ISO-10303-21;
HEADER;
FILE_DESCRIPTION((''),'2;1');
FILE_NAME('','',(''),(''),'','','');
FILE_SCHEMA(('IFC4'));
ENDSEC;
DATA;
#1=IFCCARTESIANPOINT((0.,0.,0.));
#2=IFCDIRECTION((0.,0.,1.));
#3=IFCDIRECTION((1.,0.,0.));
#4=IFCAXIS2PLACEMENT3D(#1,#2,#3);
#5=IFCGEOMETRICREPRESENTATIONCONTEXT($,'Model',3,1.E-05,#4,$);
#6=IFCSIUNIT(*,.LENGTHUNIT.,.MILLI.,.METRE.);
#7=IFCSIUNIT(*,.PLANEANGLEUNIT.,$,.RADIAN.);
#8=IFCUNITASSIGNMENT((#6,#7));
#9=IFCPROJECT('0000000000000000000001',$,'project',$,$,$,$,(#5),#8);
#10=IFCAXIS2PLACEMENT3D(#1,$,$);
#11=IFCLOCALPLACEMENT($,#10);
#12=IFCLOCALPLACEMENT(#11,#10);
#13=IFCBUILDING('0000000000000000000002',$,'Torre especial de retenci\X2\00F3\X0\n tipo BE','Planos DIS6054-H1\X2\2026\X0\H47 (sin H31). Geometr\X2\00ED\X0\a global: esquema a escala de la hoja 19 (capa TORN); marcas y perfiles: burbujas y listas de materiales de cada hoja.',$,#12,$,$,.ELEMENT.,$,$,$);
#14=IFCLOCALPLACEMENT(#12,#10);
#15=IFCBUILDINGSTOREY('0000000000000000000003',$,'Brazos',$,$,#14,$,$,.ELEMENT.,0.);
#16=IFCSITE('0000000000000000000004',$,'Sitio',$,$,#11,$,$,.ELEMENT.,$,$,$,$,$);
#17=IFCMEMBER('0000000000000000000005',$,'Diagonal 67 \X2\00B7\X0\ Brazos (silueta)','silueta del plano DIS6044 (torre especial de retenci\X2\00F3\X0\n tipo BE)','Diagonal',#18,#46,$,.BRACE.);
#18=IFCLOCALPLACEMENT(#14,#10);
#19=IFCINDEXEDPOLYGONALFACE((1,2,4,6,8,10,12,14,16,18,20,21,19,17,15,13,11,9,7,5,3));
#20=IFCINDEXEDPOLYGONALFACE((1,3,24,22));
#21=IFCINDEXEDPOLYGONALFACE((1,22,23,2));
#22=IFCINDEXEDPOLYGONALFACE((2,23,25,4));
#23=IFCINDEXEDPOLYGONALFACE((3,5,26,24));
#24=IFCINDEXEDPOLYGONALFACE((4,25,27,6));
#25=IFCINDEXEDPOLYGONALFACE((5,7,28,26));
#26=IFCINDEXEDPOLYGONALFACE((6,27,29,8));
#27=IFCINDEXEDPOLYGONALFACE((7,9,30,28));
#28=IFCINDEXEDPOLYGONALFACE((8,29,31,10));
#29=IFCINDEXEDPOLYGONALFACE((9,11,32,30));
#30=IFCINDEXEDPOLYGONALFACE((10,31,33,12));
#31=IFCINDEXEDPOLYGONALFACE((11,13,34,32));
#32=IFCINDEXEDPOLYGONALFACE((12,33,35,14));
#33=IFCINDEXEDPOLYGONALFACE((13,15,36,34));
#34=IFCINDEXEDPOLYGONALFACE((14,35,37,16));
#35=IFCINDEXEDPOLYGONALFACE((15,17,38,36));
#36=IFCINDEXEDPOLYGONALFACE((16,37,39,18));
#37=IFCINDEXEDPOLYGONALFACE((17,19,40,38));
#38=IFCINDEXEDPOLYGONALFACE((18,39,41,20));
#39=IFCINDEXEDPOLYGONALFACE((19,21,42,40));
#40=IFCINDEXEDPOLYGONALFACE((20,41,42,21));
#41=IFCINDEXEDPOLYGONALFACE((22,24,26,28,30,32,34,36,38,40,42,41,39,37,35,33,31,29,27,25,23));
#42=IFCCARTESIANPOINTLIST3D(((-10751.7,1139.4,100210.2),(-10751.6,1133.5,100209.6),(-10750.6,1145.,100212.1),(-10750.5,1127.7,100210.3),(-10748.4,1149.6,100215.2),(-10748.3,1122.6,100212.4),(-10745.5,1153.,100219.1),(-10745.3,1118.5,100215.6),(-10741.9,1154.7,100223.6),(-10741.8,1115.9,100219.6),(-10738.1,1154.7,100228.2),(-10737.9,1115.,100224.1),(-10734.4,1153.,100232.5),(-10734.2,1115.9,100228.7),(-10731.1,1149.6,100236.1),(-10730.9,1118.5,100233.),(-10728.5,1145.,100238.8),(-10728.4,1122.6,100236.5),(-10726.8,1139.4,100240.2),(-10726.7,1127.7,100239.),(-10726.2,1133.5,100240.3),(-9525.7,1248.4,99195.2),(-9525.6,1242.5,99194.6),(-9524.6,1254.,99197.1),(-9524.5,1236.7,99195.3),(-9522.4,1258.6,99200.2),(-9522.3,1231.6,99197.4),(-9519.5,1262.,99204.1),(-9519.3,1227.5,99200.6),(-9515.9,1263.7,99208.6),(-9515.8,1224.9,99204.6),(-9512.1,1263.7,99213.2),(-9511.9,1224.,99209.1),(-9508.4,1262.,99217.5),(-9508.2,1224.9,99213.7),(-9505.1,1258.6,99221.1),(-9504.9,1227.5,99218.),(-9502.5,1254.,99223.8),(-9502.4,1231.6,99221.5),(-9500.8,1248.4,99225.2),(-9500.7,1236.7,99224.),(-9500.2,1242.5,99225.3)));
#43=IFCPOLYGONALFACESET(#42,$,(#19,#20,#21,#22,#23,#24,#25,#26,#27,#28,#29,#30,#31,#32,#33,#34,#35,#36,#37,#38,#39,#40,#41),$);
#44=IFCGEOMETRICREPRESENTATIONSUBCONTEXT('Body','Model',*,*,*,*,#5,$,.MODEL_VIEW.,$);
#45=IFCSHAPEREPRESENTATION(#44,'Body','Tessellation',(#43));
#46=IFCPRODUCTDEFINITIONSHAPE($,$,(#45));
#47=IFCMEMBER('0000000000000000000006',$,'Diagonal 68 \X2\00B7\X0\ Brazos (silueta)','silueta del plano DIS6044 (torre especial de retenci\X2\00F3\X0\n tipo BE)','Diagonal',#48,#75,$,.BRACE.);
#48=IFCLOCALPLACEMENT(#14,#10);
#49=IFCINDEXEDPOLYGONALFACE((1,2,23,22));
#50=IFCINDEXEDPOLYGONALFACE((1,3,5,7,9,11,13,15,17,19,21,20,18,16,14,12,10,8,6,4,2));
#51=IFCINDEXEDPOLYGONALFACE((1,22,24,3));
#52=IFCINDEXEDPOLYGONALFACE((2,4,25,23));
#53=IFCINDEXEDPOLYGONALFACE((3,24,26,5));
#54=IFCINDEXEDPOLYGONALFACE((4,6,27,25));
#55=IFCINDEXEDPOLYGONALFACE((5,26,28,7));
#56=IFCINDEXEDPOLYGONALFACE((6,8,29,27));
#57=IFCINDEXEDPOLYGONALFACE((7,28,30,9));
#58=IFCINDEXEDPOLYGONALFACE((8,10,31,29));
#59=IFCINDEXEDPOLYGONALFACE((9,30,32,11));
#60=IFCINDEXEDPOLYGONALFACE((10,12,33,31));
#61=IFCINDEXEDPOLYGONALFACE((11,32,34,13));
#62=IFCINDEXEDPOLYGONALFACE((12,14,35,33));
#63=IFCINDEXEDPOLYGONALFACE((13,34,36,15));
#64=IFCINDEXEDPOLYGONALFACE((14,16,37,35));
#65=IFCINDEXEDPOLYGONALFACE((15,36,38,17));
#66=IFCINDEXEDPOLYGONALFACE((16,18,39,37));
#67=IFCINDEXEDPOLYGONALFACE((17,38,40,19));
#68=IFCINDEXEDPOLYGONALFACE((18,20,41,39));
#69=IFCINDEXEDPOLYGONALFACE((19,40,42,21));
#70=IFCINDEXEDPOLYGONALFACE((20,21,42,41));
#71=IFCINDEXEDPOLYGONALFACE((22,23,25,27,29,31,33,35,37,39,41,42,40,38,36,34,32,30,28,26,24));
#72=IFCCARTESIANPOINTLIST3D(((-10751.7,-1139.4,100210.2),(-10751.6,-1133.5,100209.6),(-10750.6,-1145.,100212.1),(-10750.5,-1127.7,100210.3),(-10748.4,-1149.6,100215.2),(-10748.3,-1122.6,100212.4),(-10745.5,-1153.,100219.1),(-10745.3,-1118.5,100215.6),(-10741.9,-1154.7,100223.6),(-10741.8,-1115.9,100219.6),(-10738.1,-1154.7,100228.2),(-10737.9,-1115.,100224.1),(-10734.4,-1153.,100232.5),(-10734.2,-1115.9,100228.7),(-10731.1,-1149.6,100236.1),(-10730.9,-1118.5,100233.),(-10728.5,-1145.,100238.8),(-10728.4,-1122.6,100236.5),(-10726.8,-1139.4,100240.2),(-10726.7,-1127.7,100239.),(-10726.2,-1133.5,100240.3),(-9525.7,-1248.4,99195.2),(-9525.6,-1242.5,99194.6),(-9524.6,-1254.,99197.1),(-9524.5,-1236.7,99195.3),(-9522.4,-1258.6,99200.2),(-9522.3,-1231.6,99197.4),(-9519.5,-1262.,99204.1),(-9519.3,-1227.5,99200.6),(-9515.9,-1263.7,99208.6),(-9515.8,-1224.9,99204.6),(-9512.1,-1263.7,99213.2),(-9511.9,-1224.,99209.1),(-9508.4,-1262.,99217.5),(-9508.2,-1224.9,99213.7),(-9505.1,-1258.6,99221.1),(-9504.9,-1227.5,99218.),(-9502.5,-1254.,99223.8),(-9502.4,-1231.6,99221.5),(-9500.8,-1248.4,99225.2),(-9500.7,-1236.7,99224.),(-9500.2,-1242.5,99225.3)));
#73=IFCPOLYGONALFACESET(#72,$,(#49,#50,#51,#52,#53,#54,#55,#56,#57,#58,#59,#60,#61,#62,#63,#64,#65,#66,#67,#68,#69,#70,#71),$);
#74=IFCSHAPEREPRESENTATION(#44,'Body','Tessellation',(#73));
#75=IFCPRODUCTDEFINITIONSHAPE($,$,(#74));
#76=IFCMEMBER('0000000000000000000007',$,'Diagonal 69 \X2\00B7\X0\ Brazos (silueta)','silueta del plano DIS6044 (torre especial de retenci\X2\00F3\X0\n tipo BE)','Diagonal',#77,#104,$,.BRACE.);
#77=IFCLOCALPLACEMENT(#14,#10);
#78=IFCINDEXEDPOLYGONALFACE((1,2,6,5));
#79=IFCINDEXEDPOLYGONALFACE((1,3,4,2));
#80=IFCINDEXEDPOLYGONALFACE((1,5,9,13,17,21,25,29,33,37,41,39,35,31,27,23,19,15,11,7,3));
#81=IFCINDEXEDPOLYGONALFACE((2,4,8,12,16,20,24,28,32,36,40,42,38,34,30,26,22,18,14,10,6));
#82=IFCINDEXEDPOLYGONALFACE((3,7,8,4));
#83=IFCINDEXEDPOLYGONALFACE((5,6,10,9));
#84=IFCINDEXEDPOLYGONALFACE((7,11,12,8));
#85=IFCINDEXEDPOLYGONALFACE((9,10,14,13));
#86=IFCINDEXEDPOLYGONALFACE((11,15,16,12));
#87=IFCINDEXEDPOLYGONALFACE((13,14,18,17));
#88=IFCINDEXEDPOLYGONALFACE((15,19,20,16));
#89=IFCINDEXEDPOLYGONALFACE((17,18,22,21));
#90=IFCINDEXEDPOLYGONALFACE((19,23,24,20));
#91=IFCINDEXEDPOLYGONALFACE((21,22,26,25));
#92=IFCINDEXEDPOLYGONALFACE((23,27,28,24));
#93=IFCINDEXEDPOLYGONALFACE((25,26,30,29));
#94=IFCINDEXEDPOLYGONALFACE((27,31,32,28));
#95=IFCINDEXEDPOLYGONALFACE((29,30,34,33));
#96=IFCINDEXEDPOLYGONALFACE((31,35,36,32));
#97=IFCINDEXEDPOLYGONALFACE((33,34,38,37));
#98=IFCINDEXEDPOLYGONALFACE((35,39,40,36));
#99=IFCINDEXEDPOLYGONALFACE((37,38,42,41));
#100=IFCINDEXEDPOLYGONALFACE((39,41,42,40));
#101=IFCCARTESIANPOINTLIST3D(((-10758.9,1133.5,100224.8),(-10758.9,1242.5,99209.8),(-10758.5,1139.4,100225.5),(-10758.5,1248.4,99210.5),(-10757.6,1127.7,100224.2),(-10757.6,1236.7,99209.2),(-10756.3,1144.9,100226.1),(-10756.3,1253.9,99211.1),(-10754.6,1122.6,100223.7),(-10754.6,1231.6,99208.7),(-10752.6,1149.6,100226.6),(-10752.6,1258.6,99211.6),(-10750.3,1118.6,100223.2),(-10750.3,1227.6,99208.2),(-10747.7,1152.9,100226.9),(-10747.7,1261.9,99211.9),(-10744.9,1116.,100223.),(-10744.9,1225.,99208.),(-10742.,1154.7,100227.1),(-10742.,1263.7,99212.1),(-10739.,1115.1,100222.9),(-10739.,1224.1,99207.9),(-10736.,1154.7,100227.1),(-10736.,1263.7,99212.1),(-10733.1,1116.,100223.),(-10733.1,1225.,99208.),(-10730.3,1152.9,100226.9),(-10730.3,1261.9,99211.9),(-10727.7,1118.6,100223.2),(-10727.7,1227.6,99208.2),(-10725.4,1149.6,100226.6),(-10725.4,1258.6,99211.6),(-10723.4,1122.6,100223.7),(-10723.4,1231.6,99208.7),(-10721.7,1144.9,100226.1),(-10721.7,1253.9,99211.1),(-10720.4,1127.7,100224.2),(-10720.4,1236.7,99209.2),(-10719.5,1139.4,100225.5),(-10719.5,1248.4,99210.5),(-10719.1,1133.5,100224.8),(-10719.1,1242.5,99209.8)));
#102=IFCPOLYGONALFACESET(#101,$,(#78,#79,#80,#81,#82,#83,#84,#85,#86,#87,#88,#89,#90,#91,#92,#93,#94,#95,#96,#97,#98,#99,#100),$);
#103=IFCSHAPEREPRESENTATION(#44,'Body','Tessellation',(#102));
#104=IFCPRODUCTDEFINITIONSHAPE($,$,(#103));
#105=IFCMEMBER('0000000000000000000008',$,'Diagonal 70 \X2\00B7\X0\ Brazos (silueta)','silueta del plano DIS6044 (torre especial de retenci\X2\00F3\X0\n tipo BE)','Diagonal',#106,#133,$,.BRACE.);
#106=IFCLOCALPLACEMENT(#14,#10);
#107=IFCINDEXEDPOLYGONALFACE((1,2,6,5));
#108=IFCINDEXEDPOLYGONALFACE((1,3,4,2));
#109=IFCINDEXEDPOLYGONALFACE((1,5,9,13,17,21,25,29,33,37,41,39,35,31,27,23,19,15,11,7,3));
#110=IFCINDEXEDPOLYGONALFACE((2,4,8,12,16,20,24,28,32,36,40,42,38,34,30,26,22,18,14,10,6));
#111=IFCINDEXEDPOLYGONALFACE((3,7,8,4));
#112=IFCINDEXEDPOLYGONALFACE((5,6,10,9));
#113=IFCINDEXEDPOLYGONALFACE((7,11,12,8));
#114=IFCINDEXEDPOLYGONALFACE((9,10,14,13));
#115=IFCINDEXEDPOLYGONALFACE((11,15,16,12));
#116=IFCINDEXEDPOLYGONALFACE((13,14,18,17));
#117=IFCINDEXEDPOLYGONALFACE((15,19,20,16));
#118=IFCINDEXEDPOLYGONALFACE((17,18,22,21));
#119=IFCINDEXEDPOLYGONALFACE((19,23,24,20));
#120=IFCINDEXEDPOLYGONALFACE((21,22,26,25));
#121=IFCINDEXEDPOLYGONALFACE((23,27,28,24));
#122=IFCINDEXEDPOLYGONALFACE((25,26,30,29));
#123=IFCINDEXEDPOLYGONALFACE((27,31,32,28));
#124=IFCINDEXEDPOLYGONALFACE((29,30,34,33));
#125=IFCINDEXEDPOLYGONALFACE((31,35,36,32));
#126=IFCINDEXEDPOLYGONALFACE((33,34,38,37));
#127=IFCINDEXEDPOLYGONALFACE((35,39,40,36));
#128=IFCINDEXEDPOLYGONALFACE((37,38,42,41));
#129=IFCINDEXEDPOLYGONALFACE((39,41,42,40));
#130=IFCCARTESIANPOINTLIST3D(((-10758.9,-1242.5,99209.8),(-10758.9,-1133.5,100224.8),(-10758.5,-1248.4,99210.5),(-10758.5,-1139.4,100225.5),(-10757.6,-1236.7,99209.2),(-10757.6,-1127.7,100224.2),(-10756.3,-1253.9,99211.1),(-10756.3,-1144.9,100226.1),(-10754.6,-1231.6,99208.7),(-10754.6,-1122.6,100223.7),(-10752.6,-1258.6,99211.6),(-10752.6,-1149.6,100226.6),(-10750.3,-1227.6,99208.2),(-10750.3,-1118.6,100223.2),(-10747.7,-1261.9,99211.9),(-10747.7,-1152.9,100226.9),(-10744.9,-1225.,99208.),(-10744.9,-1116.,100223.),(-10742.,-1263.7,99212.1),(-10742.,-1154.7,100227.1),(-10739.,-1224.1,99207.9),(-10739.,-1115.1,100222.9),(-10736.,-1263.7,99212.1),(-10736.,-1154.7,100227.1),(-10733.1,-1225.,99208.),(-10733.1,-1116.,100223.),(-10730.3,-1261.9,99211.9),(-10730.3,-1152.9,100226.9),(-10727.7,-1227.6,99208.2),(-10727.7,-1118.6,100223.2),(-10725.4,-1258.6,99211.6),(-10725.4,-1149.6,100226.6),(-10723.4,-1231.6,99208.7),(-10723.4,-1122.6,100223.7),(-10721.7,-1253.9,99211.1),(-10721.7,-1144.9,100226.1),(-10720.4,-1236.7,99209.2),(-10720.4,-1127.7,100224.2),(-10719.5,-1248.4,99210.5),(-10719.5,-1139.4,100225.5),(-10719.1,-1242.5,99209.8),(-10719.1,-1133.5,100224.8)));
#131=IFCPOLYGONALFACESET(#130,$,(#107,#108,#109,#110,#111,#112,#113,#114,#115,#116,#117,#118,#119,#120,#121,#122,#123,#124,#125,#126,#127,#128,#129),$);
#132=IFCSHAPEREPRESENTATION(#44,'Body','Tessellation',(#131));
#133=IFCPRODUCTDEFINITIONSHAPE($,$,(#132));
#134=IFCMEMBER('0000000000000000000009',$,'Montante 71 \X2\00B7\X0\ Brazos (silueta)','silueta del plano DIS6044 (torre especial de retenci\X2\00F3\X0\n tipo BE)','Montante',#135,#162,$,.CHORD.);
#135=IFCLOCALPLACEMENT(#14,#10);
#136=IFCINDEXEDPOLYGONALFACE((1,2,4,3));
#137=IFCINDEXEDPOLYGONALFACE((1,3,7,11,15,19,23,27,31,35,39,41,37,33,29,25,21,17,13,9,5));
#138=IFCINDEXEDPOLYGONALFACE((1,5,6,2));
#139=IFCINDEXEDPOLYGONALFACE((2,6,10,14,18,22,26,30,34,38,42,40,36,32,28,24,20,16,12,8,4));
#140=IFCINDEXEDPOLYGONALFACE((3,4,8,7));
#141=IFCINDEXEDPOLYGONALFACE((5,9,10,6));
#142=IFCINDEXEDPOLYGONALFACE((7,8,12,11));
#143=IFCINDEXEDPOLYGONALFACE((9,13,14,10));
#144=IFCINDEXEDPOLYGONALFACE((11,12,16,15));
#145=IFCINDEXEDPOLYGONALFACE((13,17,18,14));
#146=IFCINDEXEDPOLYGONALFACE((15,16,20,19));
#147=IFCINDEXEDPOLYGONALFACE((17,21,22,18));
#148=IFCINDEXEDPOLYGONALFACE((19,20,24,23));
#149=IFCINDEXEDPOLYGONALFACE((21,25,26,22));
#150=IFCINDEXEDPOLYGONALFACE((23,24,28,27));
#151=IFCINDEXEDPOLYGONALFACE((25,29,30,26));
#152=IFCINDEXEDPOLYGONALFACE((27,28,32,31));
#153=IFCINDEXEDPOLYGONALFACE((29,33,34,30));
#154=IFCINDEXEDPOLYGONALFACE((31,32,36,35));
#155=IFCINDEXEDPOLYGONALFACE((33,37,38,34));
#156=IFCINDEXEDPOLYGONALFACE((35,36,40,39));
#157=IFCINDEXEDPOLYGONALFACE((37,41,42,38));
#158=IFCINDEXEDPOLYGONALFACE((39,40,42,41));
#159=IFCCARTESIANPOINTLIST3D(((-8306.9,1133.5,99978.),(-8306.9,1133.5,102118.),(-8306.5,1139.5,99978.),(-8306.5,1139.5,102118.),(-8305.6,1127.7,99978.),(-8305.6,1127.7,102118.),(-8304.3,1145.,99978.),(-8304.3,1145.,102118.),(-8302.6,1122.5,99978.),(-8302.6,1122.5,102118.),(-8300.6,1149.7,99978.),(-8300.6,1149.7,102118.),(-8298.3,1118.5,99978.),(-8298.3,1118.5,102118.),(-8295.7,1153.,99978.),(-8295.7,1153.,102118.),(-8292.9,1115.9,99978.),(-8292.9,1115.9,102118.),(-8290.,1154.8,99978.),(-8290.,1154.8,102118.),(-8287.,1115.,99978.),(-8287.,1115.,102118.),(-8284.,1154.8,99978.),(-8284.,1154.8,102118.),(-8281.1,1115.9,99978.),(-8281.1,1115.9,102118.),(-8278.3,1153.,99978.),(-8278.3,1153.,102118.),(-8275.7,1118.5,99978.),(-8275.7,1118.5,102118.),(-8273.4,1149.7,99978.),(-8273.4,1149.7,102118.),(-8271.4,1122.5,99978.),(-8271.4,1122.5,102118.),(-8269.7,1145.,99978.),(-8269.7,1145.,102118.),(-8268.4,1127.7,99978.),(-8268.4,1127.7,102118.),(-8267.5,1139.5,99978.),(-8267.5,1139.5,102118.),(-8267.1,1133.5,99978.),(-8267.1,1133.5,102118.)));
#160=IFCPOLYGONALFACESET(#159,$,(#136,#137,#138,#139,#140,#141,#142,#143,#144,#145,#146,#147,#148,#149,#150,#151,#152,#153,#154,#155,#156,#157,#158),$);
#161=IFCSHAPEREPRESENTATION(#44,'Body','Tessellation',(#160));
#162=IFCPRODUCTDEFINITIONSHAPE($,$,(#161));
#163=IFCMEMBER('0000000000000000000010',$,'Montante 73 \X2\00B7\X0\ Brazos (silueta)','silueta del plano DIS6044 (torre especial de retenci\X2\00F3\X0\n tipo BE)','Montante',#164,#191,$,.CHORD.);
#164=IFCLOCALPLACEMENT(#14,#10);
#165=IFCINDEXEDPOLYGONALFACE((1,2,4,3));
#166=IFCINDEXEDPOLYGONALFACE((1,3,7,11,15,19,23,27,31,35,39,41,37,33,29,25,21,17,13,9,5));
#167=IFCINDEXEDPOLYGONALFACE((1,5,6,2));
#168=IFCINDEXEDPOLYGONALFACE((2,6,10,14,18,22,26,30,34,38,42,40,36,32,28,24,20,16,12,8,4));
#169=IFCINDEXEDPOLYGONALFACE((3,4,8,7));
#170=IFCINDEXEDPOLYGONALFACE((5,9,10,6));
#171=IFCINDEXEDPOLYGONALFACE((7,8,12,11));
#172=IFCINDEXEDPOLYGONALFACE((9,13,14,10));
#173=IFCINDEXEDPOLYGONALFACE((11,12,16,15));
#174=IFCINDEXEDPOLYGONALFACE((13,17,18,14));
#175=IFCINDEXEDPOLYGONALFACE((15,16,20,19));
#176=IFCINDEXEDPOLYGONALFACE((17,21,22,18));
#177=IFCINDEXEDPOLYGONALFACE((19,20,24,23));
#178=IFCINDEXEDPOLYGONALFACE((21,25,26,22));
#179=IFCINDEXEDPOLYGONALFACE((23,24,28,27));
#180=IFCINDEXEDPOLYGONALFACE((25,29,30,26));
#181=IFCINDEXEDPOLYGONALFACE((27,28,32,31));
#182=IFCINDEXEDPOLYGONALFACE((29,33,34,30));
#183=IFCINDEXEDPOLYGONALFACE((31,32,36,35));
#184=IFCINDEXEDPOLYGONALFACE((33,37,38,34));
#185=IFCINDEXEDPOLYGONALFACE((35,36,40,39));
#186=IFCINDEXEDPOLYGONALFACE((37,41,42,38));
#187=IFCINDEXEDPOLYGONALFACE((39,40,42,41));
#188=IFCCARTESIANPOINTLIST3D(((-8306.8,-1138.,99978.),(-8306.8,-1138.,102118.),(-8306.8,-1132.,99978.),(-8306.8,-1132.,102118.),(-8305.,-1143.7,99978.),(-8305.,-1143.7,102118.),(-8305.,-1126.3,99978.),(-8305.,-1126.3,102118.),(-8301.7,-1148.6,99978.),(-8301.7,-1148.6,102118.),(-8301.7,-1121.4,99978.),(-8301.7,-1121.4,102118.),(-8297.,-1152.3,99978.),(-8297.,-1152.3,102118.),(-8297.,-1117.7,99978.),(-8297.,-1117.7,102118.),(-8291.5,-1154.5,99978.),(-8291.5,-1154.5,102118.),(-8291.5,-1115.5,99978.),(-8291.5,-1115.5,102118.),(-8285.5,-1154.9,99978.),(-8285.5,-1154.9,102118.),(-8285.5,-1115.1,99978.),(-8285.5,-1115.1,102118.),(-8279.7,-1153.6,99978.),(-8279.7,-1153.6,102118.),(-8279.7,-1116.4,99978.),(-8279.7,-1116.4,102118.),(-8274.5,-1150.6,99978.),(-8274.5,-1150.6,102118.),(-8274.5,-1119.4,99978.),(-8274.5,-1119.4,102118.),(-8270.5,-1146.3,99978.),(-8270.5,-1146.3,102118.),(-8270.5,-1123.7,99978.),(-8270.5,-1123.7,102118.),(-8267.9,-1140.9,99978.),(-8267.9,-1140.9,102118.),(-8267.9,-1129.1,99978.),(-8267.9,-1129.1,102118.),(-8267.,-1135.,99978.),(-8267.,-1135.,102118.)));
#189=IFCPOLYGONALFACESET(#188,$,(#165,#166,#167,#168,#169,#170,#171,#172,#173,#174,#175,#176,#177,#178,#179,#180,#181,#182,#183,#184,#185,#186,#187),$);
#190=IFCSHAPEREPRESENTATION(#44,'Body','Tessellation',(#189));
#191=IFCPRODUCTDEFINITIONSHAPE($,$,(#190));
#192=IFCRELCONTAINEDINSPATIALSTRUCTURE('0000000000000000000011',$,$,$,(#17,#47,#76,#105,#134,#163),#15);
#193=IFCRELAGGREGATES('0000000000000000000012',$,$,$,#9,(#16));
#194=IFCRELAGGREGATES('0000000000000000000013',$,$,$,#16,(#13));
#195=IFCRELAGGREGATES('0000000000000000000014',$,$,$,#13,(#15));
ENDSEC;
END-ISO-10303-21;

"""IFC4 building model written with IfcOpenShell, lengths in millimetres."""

from ifc_helpers import new_model, si_unit, frame, origin, origin_with_axes, place, context, subcontext, project, spatial, circle, extrude, element, save


model = new_model("IFC4")

# Units and contexts
model_context = context("Model", 3, precision=1e-05, world=origin_with_axes())
body_context = subcontext(model_context, "Body", "Model", "MODEL_VIEW")
ifc_project = project(units=[si_unit("LENGTHUNIT", "METRE", prefix="MILLI"), si_unit("PLANEANGLEUNIT", "RADIAN")], contexts=[model_context])

# Site, building, storey
site_placement = place(None, origin())
site = spatial("IfcSite", under=ifc_project, at=site_placement, Name="Sitio", CompositionType="ELEMENT")
building_placement = place(site_placement, origin())
building = spatial("IfcBuilding", under=site, at=building_placement, Name="Torre especial de retención tipo BE", Description="Planos DIS6054-H1…H47 (sin H31). Geometría global: esquema a escala de la hoja 19 (capa TORN); marcas y perfiles: burbujas y listas de materiales de cada hoja.", CompositionType="ELEMENT")
storey_placement = place(building_placement, origin())
storey = spatial("IfcBuildingStorey", under=building, at=storey_placement, Name="Brazos", CompositionType="ELEMENT", Elevation=0.0)

# Members
for number, where, z_axis, x_axis, name in (
    (1, (-9513.0, 1244.0, 99210.0), (-0.768477, -0.068323, 0.636219), (0.052628, -0.997663, -0.04357), "Diagonal 67 · Brazos (silueta)"),
    (2, (-9513.0, -1244.0, 99210.0), (-0.768477, 0.068323, 0.636219), (0.052628, 0.997663, -0.04357), "Diagonal 68 · Brazos (silueta)"),
):
    element("IfcMember", number, at=place(storey_placement, frame(where, z_axis=z_axis, x_axis=x_axis)), inside=storey, Name=name, Description="silueta del plano DIS6044 (torre especial de retención tipo BE)", ObjectType="Diagonal", PredefinedType="BRACE", context=body_context, shape_type="SweptSolid", body=[
        extrude(circle(Radius=20.0), None, (0.0, 0.0, 1.0), 1595.4),
    ])
for number, where, z_axis, x_axis, name in (
    (3, (-10739.0, 1135.0, 100225.0), (0.0, 0.106775, -0.994283), (0.0, -0.994283, -0.106775), "Diagonal 69 · Brazos (silueta)"),
    (4, (-10739.0, -1135.0, 100225.0), (0.0, -0.106775, -0.994283), (0.0, 0.994283, -0.106775), "Diagonal 70 · Brazos (silueta)"),
):
    element("IfcMember", number, at=place(storey_placement, frame(where, z_axis=z_axis, x_axis=x_axis)), inside=storey, Name=name, Description="silueta del plano DIS6044 (torre especial de retención tipo BE)", ObjectType="Diagonal", PredefinedType="BRACE", context=body_context, shape_type="SweptSolid", body=[
        extrude(circle(Radius=20.0), None, (0.0, 0.0, 1.0), 1020.8),
    ])
for number, where, z_axis, x_axis, name in (
    (5, (-8287.0, 1135.0, 99978.0), (0.0, 0.0, 1.0), (0.0, -1.0, 0.0), "Montante 71 · Brazos (silueta)"),
    (6, (-8287.0, -1135.0, 99978.0), (0.0, 0.0, 1.0), (1.0, 0.0, 0.0), "Montante 73 · Brazos (silueta)"),
):
    element("IfcMember", number, at=place(storey_placement, frame(where, z_axis=z_axis, x_axis=x_axis)), inside=storey, Name=name, Description="silueta del plano DIS6044 (torre especial de retención tipo BE)", ObjectType="Montante", PredefinedType="CHORD", context=body_context, shape_type="SweptSolid", body=[
        extrude(circle(Radius=20.0), None, (0.0, 0.0, 1.0), 2140.0),
    ])

save(model, "model.ifc")
